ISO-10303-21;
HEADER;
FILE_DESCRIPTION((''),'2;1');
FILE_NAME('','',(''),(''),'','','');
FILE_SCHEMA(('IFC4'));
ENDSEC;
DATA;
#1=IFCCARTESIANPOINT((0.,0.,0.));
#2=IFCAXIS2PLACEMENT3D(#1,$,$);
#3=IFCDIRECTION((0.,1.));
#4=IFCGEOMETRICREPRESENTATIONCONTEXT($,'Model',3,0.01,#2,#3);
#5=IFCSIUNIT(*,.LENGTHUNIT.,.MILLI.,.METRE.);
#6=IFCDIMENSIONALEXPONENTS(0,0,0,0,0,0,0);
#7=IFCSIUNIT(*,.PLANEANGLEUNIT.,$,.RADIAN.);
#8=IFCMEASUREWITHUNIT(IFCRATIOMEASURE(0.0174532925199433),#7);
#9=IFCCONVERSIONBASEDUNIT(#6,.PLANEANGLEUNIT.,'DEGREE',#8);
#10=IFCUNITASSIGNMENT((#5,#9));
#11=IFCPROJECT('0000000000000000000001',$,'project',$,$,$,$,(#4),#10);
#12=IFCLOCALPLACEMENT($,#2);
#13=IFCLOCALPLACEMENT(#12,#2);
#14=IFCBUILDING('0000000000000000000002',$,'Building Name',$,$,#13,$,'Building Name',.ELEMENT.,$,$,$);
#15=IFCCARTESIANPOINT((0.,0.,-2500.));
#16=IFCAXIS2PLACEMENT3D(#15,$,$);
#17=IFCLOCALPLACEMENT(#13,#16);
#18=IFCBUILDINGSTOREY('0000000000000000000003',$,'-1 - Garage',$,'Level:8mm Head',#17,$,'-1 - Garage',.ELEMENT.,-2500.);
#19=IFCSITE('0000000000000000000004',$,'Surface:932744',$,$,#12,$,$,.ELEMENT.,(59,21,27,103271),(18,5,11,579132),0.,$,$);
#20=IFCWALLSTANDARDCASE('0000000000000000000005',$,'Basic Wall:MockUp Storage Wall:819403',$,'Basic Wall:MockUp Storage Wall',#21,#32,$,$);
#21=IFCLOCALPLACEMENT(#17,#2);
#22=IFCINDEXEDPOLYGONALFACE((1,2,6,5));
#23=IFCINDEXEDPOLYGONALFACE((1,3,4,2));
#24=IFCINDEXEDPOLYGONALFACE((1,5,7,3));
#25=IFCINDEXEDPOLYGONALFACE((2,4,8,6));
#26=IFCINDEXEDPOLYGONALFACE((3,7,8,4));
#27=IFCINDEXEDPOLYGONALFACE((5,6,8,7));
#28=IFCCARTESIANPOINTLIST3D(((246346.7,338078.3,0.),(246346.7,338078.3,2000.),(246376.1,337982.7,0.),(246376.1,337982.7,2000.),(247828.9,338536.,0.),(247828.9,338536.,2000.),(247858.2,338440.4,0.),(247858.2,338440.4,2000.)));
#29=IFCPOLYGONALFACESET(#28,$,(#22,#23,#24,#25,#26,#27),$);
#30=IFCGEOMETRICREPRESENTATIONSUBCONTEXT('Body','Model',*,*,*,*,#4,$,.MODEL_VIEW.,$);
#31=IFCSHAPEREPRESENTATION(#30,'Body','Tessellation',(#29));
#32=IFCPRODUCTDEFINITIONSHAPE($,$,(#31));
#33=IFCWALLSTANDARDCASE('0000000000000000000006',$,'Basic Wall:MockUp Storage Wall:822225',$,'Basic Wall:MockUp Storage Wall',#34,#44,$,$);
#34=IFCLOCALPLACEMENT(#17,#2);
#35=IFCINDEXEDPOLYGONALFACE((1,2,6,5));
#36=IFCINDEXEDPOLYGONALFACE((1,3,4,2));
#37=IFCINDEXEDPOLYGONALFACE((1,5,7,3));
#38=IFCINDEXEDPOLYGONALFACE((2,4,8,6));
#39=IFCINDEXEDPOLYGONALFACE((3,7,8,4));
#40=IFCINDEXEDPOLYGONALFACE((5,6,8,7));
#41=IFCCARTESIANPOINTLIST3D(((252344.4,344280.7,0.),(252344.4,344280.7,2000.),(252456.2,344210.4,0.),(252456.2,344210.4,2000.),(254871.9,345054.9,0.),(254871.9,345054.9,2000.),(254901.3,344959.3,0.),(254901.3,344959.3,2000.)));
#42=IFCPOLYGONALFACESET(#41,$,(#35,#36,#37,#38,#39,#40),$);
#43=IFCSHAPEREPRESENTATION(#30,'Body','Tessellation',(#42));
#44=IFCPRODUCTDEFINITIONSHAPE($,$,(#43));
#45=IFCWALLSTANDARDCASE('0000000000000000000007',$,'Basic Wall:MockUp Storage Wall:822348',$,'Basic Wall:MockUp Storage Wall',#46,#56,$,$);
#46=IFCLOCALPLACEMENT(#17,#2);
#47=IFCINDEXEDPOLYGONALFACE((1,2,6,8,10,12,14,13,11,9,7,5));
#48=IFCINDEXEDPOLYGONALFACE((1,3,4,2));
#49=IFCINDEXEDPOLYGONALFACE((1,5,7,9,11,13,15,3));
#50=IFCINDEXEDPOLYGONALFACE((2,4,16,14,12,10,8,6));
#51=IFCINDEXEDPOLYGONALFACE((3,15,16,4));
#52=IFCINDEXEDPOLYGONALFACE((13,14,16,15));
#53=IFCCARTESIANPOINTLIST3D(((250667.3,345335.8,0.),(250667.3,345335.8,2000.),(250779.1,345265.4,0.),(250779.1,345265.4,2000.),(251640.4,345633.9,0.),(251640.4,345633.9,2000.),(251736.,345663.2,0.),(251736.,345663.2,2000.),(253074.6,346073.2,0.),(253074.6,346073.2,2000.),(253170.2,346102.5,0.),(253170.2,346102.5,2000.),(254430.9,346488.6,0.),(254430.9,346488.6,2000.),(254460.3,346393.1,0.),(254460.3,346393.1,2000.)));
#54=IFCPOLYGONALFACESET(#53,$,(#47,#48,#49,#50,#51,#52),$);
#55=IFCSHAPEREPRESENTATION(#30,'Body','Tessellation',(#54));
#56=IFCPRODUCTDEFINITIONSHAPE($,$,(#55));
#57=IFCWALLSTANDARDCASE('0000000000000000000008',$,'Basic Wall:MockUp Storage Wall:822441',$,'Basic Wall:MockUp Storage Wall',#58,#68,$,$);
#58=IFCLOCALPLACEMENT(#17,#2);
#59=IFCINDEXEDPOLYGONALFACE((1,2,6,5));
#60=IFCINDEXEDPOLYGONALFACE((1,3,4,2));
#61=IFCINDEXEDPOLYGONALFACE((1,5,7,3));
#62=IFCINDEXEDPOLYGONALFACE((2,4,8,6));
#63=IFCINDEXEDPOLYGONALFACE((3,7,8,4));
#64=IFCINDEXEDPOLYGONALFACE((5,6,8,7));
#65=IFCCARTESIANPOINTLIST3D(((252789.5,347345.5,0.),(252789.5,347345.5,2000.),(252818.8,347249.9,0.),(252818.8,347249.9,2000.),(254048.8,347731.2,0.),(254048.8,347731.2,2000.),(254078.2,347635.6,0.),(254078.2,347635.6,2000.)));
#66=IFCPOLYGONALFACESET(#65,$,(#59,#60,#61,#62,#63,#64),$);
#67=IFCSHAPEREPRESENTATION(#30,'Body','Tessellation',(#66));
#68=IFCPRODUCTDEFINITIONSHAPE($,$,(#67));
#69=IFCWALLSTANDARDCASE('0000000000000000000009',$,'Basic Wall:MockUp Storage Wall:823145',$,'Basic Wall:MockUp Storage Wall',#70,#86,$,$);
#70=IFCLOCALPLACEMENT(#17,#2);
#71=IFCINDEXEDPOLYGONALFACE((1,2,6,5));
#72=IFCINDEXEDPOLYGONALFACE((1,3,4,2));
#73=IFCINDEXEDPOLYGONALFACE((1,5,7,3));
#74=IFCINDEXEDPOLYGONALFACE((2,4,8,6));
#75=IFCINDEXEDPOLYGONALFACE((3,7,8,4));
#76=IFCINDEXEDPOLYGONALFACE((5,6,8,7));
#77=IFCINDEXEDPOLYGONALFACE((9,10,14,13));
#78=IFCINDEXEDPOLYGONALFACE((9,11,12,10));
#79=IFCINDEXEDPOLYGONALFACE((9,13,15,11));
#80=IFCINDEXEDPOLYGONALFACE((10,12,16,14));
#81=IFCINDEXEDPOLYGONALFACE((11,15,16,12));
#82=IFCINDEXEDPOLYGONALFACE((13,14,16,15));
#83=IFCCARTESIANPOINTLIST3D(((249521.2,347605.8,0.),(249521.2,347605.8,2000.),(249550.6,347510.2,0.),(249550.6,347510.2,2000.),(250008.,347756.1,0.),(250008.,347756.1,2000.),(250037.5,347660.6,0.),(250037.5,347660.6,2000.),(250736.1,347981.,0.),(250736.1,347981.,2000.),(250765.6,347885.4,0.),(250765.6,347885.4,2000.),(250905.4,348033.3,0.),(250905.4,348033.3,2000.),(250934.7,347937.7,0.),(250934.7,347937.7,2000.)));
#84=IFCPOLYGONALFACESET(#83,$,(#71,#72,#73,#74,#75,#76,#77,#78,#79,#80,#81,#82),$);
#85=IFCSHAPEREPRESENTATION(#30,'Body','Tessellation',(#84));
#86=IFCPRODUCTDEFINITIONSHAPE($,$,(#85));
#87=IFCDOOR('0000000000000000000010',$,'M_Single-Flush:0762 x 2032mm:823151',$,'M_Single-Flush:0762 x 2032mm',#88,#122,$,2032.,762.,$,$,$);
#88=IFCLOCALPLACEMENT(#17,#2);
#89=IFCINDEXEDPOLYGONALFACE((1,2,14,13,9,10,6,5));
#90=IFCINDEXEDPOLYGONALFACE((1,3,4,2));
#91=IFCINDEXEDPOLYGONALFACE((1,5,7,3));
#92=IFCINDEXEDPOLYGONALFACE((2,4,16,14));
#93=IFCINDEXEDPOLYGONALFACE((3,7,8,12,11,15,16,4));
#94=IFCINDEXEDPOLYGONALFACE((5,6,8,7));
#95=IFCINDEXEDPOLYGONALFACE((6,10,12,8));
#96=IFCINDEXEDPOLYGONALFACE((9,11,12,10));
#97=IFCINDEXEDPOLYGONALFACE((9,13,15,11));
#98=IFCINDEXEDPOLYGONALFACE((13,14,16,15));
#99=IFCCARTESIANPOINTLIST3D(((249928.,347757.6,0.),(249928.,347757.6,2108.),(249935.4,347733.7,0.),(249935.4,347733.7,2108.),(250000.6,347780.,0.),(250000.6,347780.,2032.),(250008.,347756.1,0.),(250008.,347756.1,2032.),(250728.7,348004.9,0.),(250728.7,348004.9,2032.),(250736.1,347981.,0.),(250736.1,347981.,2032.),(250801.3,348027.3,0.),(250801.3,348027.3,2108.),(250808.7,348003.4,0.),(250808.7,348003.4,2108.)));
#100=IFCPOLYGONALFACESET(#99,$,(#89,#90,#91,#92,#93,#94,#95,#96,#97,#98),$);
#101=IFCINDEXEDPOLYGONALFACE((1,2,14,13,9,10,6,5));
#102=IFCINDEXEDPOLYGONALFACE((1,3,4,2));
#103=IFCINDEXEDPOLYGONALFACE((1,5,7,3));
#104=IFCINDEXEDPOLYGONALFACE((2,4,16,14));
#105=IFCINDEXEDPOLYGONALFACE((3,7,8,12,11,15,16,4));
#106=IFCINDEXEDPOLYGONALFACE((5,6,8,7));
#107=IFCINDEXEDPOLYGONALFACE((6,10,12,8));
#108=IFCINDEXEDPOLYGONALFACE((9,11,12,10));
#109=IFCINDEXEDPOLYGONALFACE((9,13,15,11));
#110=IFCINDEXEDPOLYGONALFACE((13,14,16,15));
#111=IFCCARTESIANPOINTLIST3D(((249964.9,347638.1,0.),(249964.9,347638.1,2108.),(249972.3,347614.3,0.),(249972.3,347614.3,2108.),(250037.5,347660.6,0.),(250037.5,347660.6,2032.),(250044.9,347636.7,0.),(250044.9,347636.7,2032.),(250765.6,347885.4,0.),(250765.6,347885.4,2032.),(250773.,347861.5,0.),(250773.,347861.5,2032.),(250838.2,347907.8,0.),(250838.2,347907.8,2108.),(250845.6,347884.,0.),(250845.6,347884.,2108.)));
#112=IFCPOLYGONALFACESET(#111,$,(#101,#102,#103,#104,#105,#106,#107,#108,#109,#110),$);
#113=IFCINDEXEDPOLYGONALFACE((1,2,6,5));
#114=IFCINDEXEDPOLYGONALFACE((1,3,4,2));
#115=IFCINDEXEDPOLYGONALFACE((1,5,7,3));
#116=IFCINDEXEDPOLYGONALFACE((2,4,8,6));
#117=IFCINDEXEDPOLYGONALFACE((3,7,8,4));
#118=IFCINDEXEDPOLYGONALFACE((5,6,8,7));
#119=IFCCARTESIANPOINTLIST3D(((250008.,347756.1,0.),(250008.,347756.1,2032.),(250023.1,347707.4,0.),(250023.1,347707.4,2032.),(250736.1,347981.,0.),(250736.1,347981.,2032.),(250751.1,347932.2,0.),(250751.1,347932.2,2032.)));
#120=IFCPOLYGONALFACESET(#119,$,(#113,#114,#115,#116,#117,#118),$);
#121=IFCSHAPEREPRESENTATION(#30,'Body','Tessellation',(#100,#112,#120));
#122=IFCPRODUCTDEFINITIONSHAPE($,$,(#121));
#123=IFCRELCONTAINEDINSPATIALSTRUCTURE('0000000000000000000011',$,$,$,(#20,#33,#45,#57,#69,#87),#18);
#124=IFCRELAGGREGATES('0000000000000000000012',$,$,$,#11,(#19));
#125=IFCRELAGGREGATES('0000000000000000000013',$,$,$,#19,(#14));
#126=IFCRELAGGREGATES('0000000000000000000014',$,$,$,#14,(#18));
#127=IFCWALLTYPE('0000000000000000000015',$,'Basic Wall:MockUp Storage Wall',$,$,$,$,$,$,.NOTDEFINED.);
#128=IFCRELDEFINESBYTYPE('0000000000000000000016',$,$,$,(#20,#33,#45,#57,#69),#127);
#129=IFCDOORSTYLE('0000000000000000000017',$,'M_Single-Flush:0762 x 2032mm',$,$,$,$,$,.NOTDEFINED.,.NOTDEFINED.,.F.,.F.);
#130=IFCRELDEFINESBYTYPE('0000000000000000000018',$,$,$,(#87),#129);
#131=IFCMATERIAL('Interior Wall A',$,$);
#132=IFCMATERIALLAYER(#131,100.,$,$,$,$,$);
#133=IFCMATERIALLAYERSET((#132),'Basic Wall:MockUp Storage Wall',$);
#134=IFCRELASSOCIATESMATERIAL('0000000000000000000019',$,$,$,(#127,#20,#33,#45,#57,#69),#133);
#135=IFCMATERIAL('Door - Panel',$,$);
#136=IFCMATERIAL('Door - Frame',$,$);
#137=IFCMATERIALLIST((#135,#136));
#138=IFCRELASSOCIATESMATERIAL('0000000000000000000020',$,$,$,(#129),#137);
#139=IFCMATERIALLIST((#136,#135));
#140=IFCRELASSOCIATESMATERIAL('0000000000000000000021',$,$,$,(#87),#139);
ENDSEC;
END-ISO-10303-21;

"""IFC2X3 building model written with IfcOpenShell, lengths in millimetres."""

from ifc_helpers import new_model, entity, si_unit, converted_unit, direction, frame, frame_2d, origin, origin_2d_with_axis, place, context, subcontext, project, spatial, polyline, rectangle, outline, extrude, source, transform, mapped, material, material_list, layer, layer_set, layer_usage, type_object, type_shapes, element, fill, save


model = new_model("IFC2X3")

# Units and contexts
model_context = context("Model", 3, precision=0.01, world=origin(), true_north=direction((0.0, 1.0)))
body_context = subcontext(model_context, "Body", "Model", "MODEL_VIEW")
ifc_project = project(units=[si_unit("LENGTHUNIT", "METRE", prefix="MILLI"), converted_unit("PLANEANGLEUNIT", "DEGREE", entity("IfcRatioMeasure", 0.0174532925199433), si_unit("PLANEANGLEUNIT", "RADIAN"), dimensions=[0, 0, 0, 0, 0, 0, 0])], contexts=[model_context])

# Site, building, storey
site_placement = place(None, origin())
site = spatial("IfcSite", under=ifc_project, at=site_placement, Name="Surface:932744", CompositionType="ELEMENT", RefLatitude=(59, 21, 27, 103271), RefLongitude=(18, 5, 11, 579132), RefElevation=0.0)
building_placement = place(site_placement, origin())
building = spatial("IfcBuilding", under=site, at=building_placement, Name="Building Name", LongName="Building Name", CompositionType="ELEMENT")
storey_placement = place(building_placement, frame((0.0, 0.0, -2500.0)))
storey = spatial("IfcBuildingStorey", under=building, at=storey_placement, Name="-1 - Garage", ObjectType="Level:8mm Head", LongName="-1 - Garage", CompositionType="ELEMENT", Elevation=-2500.0)

# Shared definitions
ifc_material_1 = material(Name="Door - Frame")
ifc_material_2 = material(Name="Door - Panel")

# Shared definitions
ifc_material_3 = material(Name="Interior Wall A")
ifc_layer_1 = layer(ifc_material_3, 100.0)
ifc_layer_set_1 = layer_set([ifc_layer_1], Name="Basic Wall:MockUp Storage Wall")
wall_type_1 = type_object("IfcWallType", Name="Basic Wall:MockUp Storage Wall", PredefinedType="NOTDEFINED", material=ifc_layer_set_1)
ifc_material_list_1 = material_list([ifc_material_2, ifc_material_1])
door_style_1 = type_object("IfcDoorStyle", Name="M_Single-Flush:0762 x 2032mm", ConstructionType="NOTDEFINED", OperationType="NOTDEFINED", ParameterTakesPrecedence=False, Sizeable=False, material=ifc_material_list_1)
shared_shape_1 = source(origin(), body_context, "Body", "SweptSolid", [
    extrude(outline(polyline([(-457.0, -1073.0), (457.0, -1073.0), (457.0, 1035.0), (381.0, 1035.0), (381.0, -997.0), (-381.0, -997.0), (-381.0, 1035.0), (-457.0, 1035.0), (-457.0, -1073.0)])), frame((381.0, 100.0, 1035.0), z_axis=(0.0, 1.0, 0.0), x_axis=(1.0, 0.0, 0.0)), (0.0, 0.0, 1.0), 25.0),
    extrude(outline(polyline([(-1073.0, -457.0), (1035.0, -457.0), (1035.0, -381.0), (-997.0, -381.0), (-997.0, 381.0), (1035.0, 381.0), (1035.0, 457.0), (-1073.0, 457.0), (-1073.0, -457.0)])), frame((381.0, -25.0, 1035.0), z_axis=(0.0, 1.0, 0.0), x_axis=(0.0, 0.0, -1.0)), (0.0, 0.0, 1.0), 25.0),
    extrude(rectangle(XDim=51.0, YDim=762.0, at=origin_2d_with_axis()), frame((381.0, 74.5, 0.0), z_axis=(0.0, 0.0, 1.0), x_axis=(0.0, 1.0, 0.0)), (0.0, 0.0, 1.0), 2032.0),
])
type_shapes(door_style_1, [shared_shape_1])

# Walls
ifc_layer_usage_1 = layer_usage(ifc_layer_set_1, "AXIS2", "NEGATIVE", 50.0)
wall_1_placement = place(storey_placement, frame((247843.7, 338488.3, 0.0), z_axis=(0.0, 0.0, 1.0), x_axis=(-0.955473, -0.29508, 0.0)))
element("IfcWallStandardCase", 1, at=wall_1_placement, inside=storey, type_object=wall_type_1, material=ifc_layer_usage_1, Name="Basic Wall:MockUp Storage Wall:819403", ObjectType="Basic Wall:MockUp Storage Wall", context=body_context, shape_type="SweptSolid", body=[
    extrude(outline(polyline([(1551.3, -50.0), (1551.4, 50.0), (0.2, 50.0), (0.0, -50.0), (1551.3, -50.0)])), origin(), (0.0, 0.0, 1.0), 2000.0),
])
ifc_layer_usage_2 = layer_usage(ifc_layer_set_1, "AXIS2", "NEGATIVE", 50.0)
wall_2_placement = place(storey_placement, frame((254886.7, 345007.1, 0.0), z_axis=(0.0, 0.0, 1.0), x_axis=(-0.956149, -0.29288, 0.0)))
element("IfcWallStandardCase", 2, at=wall_2_placement, inside=storey, type_object=wall_type_1, material=ifc_layer_usage_2, Name="Basic Wall:MockUp Storage Wall:822225", ObjectType="Basic Wall:MockUp Storage Wall", context=body_context, shape_type="SweptSolid", body=[
    extrude(outline(polyline([(2643.5, -50.0), (2557.2, 50.0), (0.0, 50.0), (0.1, -50.0), (2643.5, -50.0)])), origin(), (0.0, 0.0, 1.0), 2000.0),
])
ifc_layer_usage_3 = layer_usage(ifc_layer_set_1, "AXIS2", "NEGATIVE", 50.0)
wall_3_placement = place(storey_placement, frame((254445.7, 346440.9, 0.0), z_axis=(0.0, 0.0, 1.0), x_axis=(-0.956149, -0.29288, 0.0)))
element("IfcWallStandardCase", 3, at=wall_3_placement, inside=storey, type_object=wall_type_1, material=ifc_layer_usage_3, Name="Basic Wall:MockUp Storage Wall:822348", ObjectType="Basic Wall:MockUp Storage Wall", context=body_context, shape_type="SweptSolid", body=[
    extrude(outline(polyline([(3936.4, -50.0), (3850.1, 50.0), (0.0, 50.0), (0.1, -50.0), (1318.6, -50.0), (1418.6, -50.0), (2818.6, -50.0), (2918.6, -50.0), (3936.4, -50.0)])), origin(), (0.0, 0.0, 1.0), 2000.0),
])
ifc_layer_usage_4 = layer_usage(ifc_layer_set_1, "AXIS2", "NEGATIVE", 50.0)
wall_4_placement = place(storey_placement, frame((254063.5, 347683.4, 0.0), z_axis=(0.0, 0.0, 1.0), x_axis=(-0.956149, -0.29288, 0.0)))
element("IfcWallStandardCase", 4, at=wall_4_placement, inside=storey, type_object=wall_type_1, material=ifc_layer_usage_4, Name="Basic Wall:MockUp Storage Wall:822441", ObjectType="Basic Wall:MockUp Storage Wall", context=body_context, shape_type="SweptSolid", body=[
    extrude(outline(polyline([(1317.1, -50.0), (1317.1, 50.0), (0.0, 50.0), (0.1, -50.0), (1317.1, -50.0)])), origin(), (0.0, 0.0, 1.0), 2000.0),
])

# Wall, opening, door
ifc_layer_usage_5 = layer_usage(ifc_layer_set_1, "AXIS2", "NEGATIVE", 50.0)
wall_5_placement = place(storey_placement, frame((250920.2, 347985.5, 0.0), z_axis=(0.0, 0.0, 1.0), x_axis=(-0.955473, -0.29508, 0.0)))
wall_5 = element("IfcWallStandardCase", 5, at=wall_5_placement, inside=storey, type_object=wall_type_1, material=ifc_layer_usage_5, Name="Basic Wall:MockUp Storage Wall:823145", ObjectType="Basic Wall:MockUp Storage Wall", context=body_context, shape_type="SweptSolid", body=[
    extrude(outline(polyline([(0.2, 50.0), (0.0, -50.0), (1448.7, -50.0), (1448.8, 50.0), (0.2, 50.0)])), origin(), (0.0, 0.0, 1.0), 2000.0),
])
opening_1_placement = place(wall_5_placement, frame((939.3, 50.0, 0.0)))
opening_1 = element("IfcOpeningElement", 6, at=opening_1_placement, cuts=wall_5, ObjectType="Opening", context=body_context, shape_type="SweptSolid", body=[
    extrude(rectangle(XDim=762.0, YDim=2032.0, at=frame_2d((1016.0, 381.0), x_axis=(0.0, 1.0))), frame((0.0, 0.0, 0.0), z_axis=(0.0, -1.0, 0.0), x_axis=(0.0, 0.0, 1.0)), (0.0, 0.0, 1.0), 100.0),
])
ifc_material_list_2 = material_list([ifc_material_1, ifc_material_2])
door_1_placement = place(opening_1_placement, frame((0.0, 0.0, 0.0), z_axis=(0.0, 0.0, 1.0), x_axis=(-1.0, 0.0, 0.0)))
door_1 = element("IfcDoor", 7, at=door_1_placement, inside=storey, type_object=door_style_1, material=ifc_material_list_2, Name="M_Single-Flush:0762 x 2032mm:823151", ObjectType="M_Single-Flush:0762 x 2032mm", OverallHeight=2032.0, OverallWidth=762.0, context=body_context, shape_type="MappedRepresentation", body=[
    mapped(shared_shape_1, transform((0.0, 0.0, 0.0), scale=1.0)),
])
fill(opening_1, door_1)

save(model, "model.ifc")
